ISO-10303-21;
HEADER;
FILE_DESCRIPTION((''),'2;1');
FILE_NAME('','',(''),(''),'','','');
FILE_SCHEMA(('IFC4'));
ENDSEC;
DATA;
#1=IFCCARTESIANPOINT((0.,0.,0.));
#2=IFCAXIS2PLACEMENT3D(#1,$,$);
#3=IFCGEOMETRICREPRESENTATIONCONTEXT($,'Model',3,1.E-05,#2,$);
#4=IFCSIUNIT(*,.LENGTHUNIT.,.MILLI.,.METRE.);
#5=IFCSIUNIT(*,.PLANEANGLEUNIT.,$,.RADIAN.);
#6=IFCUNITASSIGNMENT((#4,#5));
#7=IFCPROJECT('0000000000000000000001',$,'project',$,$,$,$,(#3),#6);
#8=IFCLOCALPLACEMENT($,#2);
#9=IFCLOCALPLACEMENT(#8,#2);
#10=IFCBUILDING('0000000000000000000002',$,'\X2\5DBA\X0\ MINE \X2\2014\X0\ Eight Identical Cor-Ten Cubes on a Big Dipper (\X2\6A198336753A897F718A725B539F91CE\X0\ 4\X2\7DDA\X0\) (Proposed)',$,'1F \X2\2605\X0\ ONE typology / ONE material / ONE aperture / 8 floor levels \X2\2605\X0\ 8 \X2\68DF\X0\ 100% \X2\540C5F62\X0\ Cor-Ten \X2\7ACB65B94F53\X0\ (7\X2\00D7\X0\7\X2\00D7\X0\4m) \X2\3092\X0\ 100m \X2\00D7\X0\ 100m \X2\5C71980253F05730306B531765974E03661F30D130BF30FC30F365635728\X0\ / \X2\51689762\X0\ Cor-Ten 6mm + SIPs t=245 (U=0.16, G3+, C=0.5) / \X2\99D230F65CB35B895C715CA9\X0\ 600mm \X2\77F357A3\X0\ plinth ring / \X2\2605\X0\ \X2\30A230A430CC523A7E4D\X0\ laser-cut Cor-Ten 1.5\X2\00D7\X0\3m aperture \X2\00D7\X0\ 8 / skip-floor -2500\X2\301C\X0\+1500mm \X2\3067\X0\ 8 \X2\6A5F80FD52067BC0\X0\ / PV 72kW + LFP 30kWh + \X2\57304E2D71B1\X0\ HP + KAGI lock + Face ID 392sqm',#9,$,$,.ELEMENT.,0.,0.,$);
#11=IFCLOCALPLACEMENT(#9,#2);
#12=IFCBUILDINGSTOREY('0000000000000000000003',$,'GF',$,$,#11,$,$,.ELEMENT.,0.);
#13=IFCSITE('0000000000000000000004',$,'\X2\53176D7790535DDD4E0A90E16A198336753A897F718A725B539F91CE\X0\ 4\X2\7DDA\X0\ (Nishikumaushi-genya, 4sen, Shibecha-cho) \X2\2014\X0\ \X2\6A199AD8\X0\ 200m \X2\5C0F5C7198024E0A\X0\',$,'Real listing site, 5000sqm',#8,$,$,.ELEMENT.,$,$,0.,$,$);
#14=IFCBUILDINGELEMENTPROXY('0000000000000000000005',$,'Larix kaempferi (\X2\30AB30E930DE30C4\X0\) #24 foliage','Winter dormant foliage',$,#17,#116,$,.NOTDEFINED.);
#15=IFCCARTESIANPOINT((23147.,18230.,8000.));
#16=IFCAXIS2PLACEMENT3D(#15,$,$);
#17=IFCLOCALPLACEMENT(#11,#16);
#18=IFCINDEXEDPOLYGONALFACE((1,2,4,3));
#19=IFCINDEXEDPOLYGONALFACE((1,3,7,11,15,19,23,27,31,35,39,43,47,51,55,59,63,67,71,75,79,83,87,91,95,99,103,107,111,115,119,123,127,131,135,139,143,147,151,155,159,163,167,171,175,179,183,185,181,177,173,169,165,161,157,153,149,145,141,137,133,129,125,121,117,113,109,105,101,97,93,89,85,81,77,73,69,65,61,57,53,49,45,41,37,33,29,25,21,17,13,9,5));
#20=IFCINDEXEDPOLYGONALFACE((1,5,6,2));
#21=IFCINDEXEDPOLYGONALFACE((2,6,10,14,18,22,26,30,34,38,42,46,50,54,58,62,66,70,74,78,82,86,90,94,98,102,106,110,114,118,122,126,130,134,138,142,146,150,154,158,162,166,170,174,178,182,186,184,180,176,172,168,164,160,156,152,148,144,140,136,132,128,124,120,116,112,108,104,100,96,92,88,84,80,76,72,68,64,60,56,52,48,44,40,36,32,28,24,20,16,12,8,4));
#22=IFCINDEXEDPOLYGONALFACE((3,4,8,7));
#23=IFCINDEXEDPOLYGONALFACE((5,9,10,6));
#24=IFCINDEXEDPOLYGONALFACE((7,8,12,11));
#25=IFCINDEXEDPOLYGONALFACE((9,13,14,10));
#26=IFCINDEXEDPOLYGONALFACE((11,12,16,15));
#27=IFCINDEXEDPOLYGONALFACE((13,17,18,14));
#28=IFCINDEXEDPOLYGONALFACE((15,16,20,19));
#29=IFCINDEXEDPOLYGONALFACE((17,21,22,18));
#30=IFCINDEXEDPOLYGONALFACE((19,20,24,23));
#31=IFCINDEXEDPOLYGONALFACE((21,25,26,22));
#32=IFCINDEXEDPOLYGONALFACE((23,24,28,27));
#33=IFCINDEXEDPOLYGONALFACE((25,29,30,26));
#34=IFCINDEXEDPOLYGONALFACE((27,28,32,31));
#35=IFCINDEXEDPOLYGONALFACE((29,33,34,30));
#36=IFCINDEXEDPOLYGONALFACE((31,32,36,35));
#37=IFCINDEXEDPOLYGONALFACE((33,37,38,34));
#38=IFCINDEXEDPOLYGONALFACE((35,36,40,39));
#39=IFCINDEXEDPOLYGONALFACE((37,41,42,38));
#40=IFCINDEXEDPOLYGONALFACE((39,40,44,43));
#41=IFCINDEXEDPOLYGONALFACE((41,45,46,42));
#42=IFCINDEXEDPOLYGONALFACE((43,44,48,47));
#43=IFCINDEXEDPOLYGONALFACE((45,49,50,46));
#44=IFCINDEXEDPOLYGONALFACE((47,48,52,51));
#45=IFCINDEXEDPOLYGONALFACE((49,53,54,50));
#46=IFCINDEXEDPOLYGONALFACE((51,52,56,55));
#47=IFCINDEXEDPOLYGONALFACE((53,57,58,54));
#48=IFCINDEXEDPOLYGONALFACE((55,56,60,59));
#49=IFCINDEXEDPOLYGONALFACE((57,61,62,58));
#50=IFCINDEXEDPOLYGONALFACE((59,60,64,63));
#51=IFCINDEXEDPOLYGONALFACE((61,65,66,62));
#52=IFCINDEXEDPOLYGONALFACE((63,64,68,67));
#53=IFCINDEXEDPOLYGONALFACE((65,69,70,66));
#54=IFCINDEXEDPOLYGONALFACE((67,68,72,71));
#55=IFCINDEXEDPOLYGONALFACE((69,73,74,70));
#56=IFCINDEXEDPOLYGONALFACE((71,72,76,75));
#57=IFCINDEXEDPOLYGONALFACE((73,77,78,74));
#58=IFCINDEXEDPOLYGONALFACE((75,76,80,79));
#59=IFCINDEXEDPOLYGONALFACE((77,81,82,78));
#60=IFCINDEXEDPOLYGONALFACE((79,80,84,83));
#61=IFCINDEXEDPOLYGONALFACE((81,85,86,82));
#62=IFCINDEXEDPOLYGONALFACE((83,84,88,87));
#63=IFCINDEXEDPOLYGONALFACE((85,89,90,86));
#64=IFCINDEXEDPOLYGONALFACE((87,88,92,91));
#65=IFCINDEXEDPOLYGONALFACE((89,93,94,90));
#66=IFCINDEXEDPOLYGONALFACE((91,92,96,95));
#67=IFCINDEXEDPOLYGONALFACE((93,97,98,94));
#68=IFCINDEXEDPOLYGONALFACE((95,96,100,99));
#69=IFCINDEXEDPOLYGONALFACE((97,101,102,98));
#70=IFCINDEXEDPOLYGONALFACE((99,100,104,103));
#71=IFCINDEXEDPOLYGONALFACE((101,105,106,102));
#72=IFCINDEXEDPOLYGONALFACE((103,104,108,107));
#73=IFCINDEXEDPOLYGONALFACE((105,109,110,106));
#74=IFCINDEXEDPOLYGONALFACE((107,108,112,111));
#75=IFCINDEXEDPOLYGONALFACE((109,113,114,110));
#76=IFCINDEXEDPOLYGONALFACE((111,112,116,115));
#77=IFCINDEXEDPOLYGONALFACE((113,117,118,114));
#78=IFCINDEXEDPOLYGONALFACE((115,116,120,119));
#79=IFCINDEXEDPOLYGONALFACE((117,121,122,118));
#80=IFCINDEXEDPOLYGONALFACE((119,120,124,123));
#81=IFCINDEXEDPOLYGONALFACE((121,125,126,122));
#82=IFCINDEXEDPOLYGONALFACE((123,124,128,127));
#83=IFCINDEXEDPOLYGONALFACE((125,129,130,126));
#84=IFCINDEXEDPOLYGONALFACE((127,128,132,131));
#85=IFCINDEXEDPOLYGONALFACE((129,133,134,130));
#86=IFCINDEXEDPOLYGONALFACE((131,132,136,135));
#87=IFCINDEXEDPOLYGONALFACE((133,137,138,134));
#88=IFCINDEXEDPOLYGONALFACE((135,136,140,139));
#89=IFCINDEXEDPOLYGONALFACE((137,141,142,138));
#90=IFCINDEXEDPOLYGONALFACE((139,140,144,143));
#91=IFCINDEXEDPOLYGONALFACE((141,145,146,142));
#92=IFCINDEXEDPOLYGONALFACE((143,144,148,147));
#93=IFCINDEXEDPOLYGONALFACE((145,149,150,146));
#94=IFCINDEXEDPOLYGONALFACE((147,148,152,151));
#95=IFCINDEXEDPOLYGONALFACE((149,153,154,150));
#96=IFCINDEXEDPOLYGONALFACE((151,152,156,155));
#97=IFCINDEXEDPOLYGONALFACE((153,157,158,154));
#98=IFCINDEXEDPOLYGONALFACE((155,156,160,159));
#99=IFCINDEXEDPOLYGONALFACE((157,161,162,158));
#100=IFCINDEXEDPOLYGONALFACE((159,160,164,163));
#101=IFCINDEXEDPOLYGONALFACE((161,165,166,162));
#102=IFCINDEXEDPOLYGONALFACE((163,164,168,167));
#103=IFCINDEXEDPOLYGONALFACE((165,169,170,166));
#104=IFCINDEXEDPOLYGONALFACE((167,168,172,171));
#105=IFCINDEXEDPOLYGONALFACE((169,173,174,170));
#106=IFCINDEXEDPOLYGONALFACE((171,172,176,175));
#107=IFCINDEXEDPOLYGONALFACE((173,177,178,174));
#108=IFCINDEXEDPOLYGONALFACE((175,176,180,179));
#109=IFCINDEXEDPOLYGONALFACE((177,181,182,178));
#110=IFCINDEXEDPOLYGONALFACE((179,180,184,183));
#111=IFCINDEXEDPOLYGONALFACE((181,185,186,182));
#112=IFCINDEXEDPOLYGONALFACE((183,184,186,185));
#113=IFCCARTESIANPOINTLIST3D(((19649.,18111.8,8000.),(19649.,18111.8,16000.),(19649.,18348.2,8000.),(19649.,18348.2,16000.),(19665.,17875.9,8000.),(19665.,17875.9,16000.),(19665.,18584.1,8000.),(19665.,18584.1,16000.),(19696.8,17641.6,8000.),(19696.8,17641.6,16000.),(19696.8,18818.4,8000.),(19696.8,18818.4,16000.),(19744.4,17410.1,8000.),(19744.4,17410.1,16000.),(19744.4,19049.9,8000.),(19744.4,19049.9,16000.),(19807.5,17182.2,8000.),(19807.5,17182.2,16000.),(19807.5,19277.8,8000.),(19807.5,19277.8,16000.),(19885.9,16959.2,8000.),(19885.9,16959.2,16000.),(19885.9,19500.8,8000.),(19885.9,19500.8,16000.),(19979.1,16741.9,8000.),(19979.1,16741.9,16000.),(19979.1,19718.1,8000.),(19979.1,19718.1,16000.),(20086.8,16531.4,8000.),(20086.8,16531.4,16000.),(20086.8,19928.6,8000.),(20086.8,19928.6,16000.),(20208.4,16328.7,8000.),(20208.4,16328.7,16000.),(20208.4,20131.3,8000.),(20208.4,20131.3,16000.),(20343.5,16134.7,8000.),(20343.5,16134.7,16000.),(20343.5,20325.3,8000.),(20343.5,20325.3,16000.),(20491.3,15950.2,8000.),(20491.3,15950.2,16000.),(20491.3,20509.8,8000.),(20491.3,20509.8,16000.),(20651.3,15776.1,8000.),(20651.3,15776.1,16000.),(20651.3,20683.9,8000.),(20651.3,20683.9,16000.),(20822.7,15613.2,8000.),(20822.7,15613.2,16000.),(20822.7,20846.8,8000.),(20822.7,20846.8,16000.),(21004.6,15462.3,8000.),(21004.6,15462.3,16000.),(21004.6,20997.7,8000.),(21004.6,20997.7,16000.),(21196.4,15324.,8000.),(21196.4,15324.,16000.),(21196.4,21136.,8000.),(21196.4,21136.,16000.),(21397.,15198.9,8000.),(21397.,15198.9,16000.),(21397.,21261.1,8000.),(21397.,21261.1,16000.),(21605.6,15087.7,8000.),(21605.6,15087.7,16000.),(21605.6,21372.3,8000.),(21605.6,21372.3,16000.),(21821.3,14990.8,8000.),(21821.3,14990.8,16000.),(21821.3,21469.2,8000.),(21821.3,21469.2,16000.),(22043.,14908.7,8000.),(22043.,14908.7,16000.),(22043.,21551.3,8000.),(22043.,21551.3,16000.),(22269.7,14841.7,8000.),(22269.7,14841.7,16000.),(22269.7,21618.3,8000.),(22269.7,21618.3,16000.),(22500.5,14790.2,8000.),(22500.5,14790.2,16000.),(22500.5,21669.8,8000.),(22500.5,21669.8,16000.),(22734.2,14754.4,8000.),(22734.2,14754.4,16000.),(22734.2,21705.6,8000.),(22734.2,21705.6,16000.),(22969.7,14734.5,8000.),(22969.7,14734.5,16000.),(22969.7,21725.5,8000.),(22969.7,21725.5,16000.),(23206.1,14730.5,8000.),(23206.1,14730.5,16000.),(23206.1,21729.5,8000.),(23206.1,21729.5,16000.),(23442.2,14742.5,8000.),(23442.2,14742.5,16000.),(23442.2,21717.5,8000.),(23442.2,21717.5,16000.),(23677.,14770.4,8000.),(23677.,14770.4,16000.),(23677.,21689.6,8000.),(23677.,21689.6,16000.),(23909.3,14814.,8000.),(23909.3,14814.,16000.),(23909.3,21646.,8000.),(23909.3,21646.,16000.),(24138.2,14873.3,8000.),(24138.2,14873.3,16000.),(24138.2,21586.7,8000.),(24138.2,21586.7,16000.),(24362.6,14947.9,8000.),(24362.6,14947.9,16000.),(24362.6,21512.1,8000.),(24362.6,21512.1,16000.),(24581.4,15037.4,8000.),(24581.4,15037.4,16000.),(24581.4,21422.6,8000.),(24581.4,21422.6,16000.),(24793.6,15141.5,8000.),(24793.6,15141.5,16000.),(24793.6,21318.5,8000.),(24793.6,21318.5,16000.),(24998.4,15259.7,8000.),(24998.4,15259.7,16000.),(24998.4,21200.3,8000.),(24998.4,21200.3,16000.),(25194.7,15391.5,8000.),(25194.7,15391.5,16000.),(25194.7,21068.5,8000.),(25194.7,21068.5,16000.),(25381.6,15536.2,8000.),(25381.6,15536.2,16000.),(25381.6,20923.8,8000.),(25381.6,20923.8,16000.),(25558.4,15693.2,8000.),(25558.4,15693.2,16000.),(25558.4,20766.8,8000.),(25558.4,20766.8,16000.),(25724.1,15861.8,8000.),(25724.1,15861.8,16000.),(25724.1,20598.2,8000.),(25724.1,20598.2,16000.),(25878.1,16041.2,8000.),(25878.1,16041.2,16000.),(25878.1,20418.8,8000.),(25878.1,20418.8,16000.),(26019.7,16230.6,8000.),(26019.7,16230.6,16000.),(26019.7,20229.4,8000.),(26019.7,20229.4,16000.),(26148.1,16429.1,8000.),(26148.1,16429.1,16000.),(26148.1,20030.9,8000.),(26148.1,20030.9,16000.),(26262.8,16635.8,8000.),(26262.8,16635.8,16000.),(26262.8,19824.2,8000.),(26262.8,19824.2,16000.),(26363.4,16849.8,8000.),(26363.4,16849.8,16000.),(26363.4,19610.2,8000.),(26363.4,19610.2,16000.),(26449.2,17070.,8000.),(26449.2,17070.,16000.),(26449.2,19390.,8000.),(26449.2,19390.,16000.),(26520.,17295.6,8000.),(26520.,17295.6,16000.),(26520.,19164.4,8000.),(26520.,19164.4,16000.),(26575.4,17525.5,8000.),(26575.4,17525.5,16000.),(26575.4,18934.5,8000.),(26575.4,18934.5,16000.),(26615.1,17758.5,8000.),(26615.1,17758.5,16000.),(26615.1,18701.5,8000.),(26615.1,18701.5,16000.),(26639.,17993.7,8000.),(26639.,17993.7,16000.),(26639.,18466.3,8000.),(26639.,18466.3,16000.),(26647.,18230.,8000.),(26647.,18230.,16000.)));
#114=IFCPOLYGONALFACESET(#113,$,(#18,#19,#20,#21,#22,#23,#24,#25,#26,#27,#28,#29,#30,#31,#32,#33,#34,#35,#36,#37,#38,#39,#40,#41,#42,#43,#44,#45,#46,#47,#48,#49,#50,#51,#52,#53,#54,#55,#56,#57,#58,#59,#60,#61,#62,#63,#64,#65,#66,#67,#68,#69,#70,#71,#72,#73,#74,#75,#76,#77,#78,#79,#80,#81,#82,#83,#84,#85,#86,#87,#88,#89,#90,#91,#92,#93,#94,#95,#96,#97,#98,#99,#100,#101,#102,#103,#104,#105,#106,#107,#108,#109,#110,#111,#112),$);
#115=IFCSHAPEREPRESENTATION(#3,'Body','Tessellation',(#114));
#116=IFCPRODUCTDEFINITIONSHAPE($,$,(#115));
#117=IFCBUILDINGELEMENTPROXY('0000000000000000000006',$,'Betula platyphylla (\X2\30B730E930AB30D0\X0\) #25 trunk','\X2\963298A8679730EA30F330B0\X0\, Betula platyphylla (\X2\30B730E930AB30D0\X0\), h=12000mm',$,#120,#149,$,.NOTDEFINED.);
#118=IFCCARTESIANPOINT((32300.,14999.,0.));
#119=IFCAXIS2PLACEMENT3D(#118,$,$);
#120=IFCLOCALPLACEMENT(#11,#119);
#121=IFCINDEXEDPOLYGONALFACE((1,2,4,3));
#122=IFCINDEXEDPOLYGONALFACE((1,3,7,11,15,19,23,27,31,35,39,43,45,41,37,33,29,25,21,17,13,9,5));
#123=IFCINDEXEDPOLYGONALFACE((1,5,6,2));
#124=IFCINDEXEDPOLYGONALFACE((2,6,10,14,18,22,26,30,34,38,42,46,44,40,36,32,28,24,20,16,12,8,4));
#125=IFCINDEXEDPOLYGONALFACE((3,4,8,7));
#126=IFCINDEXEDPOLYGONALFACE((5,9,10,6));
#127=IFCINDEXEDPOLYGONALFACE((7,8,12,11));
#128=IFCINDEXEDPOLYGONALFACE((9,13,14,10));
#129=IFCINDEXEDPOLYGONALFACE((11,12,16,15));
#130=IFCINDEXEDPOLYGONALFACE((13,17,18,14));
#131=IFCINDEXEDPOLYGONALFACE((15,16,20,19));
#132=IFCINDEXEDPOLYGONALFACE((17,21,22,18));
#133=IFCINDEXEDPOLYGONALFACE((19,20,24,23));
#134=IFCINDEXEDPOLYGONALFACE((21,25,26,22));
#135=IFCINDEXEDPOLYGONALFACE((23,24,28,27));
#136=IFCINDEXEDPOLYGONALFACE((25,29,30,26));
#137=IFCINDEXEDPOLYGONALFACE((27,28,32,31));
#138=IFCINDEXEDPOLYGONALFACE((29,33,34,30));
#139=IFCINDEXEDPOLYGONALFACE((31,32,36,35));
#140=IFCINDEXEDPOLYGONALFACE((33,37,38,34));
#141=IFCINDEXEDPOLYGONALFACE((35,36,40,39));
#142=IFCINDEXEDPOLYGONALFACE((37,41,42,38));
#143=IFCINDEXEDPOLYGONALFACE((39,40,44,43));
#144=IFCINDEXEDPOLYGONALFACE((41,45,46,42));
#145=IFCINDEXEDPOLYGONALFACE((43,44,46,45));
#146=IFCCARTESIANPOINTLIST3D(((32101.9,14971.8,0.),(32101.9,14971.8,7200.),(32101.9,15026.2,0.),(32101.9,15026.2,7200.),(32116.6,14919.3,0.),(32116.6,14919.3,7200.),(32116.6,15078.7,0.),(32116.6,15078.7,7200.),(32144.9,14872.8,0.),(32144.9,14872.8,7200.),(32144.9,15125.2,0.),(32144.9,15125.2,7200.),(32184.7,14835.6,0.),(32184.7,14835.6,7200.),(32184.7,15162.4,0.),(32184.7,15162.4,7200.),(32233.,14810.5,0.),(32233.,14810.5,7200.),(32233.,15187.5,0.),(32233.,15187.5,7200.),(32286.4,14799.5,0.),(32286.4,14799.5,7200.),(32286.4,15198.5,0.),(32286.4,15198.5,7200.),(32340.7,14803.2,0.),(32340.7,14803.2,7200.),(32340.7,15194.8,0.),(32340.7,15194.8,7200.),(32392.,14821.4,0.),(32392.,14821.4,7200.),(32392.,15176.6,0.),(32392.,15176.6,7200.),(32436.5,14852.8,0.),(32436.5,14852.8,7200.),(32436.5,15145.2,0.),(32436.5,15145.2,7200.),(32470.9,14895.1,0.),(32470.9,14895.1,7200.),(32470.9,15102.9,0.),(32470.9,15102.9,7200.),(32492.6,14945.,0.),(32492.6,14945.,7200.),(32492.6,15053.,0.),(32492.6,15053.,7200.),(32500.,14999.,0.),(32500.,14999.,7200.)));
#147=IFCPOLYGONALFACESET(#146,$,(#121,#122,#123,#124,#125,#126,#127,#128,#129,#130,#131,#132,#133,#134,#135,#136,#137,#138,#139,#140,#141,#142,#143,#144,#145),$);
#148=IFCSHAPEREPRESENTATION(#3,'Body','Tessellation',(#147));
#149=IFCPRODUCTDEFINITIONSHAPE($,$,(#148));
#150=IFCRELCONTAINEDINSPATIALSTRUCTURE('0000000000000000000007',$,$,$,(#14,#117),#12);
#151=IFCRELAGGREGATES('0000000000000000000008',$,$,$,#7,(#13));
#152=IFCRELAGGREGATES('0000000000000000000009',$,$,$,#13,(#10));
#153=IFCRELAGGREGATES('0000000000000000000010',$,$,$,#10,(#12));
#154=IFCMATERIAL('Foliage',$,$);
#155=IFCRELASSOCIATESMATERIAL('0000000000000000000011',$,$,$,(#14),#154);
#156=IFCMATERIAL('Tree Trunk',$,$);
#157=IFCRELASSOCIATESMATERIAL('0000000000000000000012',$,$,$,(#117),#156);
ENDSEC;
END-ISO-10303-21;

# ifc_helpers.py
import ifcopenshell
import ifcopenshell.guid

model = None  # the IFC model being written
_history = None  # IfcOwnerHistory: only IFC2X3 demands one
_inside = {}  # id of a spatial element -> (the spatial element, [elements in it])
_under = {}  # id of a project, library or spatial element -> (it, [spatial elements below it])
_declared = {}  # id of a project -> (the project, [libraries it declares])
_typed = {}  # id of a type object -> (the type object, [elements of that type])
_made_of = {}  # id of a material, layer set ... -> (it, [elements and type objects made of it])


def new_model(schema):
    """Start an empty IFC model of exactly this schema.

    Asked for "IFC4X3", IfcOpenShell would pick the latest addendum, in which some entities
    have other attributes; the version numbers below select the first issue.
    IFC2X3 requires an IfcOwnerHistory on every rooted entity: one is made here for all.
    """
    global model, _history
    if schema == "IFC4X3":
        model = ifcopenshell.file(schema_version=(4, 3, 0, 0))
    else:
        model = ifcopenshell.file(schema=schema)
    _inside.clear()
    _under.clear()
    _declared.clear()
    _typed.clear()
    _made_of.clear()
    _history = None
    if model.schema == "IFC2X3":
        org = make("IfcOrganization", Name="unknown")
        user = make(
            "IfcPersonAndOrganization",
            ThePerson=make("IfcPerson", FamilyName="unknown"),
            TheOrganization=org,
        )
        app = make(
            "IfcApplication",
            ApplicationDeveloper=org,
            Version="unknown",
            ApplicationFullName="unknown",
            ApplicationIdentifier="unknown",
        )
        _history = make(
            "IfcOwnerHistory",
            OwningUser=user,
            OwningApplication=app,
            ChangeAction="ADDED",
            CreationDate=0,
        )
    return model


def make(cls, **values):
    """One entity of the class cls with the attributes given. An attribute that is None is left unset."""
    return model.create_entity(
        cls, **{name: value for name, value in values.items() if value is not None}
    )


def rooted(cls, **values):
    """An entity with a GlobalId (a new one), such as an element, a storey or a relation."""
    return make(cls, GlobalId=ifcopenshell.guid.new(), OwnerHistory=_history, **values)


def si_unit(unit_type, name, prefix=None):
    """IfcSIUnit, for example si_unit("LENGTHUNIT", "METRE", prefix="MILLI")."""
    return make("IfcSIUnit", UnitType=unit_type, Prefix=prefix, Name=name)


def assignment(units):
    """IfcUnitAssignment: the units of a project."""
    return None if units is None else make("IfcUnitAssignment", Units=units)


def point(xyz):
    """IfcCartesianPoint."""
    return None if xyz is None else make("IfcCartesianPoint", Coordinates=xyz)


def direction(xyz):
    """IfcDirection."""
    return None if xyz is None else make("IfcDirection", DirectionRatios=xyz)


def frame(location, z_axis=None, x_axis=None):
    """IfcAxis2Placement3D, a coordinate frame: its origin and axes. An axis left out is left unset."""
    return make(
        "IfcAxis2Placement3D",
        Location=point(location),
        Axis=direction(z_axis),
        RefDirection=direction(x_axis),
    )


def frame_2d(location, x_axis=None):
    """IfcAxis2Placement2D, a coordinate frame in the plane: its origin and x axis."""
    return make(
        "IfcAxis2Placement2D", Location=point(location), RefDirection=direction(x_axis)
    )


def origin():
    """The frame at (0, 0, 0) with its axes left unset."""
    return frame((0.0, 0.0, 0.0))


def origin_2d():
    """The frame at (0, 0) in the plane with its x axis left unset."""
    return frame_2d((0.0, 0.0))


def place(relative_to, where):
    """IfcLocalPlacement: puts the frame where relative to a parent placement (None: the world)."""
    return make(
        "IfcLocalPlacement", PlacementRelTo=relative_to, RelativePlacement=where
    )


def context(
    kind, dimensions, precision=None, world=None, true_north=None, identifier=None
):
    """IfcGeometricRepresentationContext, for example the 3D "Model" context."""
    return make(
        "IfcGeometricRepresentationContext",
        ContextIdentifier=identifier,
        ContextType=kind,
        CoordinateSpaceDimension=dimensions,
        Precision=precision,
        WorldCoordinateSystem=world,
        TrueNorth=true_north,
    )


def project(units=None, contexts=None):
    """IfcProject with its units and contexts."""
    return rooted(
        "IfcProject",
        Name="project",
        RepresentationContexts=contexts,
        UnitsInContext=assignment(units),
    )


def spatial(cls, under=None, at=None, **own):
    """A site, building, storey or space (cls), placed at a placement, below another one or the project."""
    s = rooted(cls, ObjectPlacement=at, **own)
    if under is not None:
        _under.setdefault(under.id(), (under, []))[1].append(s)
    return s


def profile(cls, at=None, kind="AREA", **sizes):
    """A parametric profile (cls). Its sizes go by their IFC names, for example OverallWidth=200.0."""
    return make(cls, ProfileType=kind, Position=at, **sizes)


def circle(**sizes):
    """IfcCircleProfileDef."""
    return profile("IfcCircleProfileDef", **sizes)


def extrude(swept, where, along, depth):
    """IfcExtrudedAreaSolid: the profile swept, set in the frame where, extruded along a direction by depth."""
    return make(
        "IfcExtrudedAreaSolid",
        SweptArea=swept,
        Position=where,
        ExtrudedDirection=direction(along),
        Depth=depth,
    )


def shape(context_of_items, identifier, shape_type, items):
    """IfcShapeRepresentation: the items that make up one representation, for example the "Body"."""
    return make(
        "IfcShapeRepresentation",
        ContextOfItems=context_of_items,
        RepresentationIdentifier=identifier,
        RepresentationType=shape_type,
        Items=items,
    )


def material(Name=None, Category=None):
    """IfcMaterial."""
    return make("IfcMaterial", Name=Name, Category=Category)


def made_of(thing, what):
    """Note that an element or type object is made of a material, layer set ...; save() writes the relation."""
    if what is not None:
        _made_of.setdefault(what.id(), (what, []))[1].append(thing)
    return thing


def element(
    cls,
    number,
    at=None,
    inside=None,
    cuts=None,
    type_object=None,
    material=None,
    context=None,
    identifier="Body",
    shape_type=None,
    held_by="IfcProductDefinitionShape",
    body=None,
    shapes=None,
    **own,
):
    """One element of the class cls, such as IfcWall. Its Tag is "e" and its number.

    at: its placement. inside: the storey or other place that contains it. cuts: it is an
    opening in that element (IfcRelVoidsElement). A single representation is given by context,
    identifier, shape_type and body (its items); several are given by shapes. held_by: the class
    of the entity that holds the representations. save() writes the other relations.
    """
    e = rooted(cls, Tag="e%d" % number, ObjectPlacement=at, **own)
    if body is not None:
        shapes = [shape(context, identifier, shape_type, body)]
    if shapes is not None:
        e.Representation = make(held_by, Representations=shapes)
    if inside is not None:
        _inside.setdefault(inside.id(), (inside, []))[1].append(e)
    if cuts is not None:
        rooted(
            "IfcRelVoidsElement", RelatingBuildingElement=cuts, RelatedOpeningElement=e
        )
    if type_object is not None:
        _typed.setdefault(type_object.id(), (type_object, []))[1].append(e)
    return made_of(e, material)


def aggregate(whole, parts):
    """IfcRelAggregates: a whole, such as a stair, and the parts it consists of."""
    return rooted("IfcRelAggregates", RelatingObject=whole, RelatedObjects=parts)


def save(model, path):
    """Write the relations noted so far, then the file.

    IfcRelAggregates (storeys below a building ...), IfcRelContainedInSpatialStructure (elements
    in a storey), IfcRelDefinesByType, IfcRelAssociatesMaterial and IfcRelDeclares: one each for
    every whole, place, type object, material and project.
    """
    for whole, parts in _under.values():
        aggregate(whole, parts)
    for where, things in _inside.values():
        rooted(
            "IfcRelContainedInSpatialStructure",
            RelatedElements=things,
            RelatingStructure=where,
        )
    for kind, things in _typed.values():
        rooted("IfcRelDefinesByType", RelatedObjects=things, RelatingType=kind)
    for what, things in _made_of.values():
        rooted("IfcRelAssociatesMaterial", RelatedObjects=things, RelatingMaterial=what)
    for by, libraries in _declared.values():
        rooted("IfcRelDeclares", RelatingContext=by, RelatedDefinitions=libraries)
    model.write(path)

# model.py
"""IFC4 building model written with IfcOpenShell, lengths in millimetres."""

from ifc_helpers import new_model, si_unit, frame, origin, origin_2d, place, context, project, spatial, circle, extrude, material, element, save


model = new_model("IFC4")

# Units and contexts
model_context = context("Model", 3, precision=1e-05, world=origin())
ifc_project = project(units=[si_unit("LENGTHUNIT", "METRE", prefix="MILLI"), si_unit("PLANEANGLEUNIT", "RADIAN")], contexts=[model_context])

# Site, building, storey
site_placement = place(None, origin())
site = spatial("IfcSite", under=ifc_project, at=site_placement, Name="北海道川上郡標茶町西熊牛原野 4線 (Nishikumaushi-genya, 4sen, Shibecha-cho) — 標高 200m 小山頂上", ObjectType="Real listing site, 5000sqm", CompositionType="ELEMENT", RefElevation=0.0)
building_placement = place(site_placement, origin())
building = spatial("IfcBuilding", under=site, at=building_placement, Name="嶺 MINE — Eight Identical Cor-Ten Cubes on a Big Dipper (標茶町西熊牛原野 4線) (Proposed)", ObjectType="1F ★ ONE typology / ONE material / ONE aperture / 8 floor levels ★ 8 棟 100% 同形 Cor-Ten 立方体 (7×7×4m) を 100m × 100m 山頂台地に北斗七星パターン散在 / 全面 Cor-Ten 6mm + SIPs t=245 (U=0.16, G3+, C=0.5) / 駒ヶ岳安山岩 600mm 石垣 plinth ring / ★ アイヌ刺繍 laser-cut Cor-Ten 1.5×3m aperture × 8 / skip-floor -2500〜+1500mm で 8 機能分節 / PV 72kW + LFP 30kWh + 地中熱 HP + KAGI lock + Face ID 392sqm", CompositionType="ELEMENT", ElevationOfRefHeight=0.0, ElevationOfTerrain=0.0)
storey_placement = place(building_placement, origin())
storey = spatial("IfcBuildingStorey", under=building, at=storey_placement, Name="GF", CompositionType="ELEMENT", Elevation=0.0)

# Building element proxies
ifc_material_1 = material(Name="Tree Trunk")
ifc_material_2 = material(Name="Foliage")
proxy_1_placement = place(storey_placement, frame((23147.0, 18230.0, 8000.0)))
element("IfcBuildingElementProxy", 1, at=proxy_1_placement, inside=storey, material=ifc_material_2, Name="Larix kaempferi (カラマツ) #24 foliage", Description="Winter dormant foliage", PredefinedType="NOTDEFINED", context=model_context, shape_type="SweptSolid", body=[
    extrude(circle(Radius=3500.0, at=origin_2d()), frame((23147.0, 18230.0, 8000.0)), (0.0, 0.0, 1.0), 8000.0),
])
proxy_2_placement = place(storey_placement, frame((32300.0, 14999.0, 0.0)))
element("IfcBuildingElementProxy", 2, at=proxy_2_placement, inside=storey, material=ifc_material_1, Name="Betula platyphylla (シラカバ) #25 trunk", Description="防風林リング, Betula platyphylla (シラカバ), h=12000mm", PredefinedType="NOTDEFINED", context=model_context, shape_type="SweptSolid", body=[
    extrude(circle(Radius=200.0, at=origin_2d()), frame((32300.0, 14999.0, 0.0)), (0.0, 0.0, 1.0), 7200.0),
])

save(model, "model.ifc")
